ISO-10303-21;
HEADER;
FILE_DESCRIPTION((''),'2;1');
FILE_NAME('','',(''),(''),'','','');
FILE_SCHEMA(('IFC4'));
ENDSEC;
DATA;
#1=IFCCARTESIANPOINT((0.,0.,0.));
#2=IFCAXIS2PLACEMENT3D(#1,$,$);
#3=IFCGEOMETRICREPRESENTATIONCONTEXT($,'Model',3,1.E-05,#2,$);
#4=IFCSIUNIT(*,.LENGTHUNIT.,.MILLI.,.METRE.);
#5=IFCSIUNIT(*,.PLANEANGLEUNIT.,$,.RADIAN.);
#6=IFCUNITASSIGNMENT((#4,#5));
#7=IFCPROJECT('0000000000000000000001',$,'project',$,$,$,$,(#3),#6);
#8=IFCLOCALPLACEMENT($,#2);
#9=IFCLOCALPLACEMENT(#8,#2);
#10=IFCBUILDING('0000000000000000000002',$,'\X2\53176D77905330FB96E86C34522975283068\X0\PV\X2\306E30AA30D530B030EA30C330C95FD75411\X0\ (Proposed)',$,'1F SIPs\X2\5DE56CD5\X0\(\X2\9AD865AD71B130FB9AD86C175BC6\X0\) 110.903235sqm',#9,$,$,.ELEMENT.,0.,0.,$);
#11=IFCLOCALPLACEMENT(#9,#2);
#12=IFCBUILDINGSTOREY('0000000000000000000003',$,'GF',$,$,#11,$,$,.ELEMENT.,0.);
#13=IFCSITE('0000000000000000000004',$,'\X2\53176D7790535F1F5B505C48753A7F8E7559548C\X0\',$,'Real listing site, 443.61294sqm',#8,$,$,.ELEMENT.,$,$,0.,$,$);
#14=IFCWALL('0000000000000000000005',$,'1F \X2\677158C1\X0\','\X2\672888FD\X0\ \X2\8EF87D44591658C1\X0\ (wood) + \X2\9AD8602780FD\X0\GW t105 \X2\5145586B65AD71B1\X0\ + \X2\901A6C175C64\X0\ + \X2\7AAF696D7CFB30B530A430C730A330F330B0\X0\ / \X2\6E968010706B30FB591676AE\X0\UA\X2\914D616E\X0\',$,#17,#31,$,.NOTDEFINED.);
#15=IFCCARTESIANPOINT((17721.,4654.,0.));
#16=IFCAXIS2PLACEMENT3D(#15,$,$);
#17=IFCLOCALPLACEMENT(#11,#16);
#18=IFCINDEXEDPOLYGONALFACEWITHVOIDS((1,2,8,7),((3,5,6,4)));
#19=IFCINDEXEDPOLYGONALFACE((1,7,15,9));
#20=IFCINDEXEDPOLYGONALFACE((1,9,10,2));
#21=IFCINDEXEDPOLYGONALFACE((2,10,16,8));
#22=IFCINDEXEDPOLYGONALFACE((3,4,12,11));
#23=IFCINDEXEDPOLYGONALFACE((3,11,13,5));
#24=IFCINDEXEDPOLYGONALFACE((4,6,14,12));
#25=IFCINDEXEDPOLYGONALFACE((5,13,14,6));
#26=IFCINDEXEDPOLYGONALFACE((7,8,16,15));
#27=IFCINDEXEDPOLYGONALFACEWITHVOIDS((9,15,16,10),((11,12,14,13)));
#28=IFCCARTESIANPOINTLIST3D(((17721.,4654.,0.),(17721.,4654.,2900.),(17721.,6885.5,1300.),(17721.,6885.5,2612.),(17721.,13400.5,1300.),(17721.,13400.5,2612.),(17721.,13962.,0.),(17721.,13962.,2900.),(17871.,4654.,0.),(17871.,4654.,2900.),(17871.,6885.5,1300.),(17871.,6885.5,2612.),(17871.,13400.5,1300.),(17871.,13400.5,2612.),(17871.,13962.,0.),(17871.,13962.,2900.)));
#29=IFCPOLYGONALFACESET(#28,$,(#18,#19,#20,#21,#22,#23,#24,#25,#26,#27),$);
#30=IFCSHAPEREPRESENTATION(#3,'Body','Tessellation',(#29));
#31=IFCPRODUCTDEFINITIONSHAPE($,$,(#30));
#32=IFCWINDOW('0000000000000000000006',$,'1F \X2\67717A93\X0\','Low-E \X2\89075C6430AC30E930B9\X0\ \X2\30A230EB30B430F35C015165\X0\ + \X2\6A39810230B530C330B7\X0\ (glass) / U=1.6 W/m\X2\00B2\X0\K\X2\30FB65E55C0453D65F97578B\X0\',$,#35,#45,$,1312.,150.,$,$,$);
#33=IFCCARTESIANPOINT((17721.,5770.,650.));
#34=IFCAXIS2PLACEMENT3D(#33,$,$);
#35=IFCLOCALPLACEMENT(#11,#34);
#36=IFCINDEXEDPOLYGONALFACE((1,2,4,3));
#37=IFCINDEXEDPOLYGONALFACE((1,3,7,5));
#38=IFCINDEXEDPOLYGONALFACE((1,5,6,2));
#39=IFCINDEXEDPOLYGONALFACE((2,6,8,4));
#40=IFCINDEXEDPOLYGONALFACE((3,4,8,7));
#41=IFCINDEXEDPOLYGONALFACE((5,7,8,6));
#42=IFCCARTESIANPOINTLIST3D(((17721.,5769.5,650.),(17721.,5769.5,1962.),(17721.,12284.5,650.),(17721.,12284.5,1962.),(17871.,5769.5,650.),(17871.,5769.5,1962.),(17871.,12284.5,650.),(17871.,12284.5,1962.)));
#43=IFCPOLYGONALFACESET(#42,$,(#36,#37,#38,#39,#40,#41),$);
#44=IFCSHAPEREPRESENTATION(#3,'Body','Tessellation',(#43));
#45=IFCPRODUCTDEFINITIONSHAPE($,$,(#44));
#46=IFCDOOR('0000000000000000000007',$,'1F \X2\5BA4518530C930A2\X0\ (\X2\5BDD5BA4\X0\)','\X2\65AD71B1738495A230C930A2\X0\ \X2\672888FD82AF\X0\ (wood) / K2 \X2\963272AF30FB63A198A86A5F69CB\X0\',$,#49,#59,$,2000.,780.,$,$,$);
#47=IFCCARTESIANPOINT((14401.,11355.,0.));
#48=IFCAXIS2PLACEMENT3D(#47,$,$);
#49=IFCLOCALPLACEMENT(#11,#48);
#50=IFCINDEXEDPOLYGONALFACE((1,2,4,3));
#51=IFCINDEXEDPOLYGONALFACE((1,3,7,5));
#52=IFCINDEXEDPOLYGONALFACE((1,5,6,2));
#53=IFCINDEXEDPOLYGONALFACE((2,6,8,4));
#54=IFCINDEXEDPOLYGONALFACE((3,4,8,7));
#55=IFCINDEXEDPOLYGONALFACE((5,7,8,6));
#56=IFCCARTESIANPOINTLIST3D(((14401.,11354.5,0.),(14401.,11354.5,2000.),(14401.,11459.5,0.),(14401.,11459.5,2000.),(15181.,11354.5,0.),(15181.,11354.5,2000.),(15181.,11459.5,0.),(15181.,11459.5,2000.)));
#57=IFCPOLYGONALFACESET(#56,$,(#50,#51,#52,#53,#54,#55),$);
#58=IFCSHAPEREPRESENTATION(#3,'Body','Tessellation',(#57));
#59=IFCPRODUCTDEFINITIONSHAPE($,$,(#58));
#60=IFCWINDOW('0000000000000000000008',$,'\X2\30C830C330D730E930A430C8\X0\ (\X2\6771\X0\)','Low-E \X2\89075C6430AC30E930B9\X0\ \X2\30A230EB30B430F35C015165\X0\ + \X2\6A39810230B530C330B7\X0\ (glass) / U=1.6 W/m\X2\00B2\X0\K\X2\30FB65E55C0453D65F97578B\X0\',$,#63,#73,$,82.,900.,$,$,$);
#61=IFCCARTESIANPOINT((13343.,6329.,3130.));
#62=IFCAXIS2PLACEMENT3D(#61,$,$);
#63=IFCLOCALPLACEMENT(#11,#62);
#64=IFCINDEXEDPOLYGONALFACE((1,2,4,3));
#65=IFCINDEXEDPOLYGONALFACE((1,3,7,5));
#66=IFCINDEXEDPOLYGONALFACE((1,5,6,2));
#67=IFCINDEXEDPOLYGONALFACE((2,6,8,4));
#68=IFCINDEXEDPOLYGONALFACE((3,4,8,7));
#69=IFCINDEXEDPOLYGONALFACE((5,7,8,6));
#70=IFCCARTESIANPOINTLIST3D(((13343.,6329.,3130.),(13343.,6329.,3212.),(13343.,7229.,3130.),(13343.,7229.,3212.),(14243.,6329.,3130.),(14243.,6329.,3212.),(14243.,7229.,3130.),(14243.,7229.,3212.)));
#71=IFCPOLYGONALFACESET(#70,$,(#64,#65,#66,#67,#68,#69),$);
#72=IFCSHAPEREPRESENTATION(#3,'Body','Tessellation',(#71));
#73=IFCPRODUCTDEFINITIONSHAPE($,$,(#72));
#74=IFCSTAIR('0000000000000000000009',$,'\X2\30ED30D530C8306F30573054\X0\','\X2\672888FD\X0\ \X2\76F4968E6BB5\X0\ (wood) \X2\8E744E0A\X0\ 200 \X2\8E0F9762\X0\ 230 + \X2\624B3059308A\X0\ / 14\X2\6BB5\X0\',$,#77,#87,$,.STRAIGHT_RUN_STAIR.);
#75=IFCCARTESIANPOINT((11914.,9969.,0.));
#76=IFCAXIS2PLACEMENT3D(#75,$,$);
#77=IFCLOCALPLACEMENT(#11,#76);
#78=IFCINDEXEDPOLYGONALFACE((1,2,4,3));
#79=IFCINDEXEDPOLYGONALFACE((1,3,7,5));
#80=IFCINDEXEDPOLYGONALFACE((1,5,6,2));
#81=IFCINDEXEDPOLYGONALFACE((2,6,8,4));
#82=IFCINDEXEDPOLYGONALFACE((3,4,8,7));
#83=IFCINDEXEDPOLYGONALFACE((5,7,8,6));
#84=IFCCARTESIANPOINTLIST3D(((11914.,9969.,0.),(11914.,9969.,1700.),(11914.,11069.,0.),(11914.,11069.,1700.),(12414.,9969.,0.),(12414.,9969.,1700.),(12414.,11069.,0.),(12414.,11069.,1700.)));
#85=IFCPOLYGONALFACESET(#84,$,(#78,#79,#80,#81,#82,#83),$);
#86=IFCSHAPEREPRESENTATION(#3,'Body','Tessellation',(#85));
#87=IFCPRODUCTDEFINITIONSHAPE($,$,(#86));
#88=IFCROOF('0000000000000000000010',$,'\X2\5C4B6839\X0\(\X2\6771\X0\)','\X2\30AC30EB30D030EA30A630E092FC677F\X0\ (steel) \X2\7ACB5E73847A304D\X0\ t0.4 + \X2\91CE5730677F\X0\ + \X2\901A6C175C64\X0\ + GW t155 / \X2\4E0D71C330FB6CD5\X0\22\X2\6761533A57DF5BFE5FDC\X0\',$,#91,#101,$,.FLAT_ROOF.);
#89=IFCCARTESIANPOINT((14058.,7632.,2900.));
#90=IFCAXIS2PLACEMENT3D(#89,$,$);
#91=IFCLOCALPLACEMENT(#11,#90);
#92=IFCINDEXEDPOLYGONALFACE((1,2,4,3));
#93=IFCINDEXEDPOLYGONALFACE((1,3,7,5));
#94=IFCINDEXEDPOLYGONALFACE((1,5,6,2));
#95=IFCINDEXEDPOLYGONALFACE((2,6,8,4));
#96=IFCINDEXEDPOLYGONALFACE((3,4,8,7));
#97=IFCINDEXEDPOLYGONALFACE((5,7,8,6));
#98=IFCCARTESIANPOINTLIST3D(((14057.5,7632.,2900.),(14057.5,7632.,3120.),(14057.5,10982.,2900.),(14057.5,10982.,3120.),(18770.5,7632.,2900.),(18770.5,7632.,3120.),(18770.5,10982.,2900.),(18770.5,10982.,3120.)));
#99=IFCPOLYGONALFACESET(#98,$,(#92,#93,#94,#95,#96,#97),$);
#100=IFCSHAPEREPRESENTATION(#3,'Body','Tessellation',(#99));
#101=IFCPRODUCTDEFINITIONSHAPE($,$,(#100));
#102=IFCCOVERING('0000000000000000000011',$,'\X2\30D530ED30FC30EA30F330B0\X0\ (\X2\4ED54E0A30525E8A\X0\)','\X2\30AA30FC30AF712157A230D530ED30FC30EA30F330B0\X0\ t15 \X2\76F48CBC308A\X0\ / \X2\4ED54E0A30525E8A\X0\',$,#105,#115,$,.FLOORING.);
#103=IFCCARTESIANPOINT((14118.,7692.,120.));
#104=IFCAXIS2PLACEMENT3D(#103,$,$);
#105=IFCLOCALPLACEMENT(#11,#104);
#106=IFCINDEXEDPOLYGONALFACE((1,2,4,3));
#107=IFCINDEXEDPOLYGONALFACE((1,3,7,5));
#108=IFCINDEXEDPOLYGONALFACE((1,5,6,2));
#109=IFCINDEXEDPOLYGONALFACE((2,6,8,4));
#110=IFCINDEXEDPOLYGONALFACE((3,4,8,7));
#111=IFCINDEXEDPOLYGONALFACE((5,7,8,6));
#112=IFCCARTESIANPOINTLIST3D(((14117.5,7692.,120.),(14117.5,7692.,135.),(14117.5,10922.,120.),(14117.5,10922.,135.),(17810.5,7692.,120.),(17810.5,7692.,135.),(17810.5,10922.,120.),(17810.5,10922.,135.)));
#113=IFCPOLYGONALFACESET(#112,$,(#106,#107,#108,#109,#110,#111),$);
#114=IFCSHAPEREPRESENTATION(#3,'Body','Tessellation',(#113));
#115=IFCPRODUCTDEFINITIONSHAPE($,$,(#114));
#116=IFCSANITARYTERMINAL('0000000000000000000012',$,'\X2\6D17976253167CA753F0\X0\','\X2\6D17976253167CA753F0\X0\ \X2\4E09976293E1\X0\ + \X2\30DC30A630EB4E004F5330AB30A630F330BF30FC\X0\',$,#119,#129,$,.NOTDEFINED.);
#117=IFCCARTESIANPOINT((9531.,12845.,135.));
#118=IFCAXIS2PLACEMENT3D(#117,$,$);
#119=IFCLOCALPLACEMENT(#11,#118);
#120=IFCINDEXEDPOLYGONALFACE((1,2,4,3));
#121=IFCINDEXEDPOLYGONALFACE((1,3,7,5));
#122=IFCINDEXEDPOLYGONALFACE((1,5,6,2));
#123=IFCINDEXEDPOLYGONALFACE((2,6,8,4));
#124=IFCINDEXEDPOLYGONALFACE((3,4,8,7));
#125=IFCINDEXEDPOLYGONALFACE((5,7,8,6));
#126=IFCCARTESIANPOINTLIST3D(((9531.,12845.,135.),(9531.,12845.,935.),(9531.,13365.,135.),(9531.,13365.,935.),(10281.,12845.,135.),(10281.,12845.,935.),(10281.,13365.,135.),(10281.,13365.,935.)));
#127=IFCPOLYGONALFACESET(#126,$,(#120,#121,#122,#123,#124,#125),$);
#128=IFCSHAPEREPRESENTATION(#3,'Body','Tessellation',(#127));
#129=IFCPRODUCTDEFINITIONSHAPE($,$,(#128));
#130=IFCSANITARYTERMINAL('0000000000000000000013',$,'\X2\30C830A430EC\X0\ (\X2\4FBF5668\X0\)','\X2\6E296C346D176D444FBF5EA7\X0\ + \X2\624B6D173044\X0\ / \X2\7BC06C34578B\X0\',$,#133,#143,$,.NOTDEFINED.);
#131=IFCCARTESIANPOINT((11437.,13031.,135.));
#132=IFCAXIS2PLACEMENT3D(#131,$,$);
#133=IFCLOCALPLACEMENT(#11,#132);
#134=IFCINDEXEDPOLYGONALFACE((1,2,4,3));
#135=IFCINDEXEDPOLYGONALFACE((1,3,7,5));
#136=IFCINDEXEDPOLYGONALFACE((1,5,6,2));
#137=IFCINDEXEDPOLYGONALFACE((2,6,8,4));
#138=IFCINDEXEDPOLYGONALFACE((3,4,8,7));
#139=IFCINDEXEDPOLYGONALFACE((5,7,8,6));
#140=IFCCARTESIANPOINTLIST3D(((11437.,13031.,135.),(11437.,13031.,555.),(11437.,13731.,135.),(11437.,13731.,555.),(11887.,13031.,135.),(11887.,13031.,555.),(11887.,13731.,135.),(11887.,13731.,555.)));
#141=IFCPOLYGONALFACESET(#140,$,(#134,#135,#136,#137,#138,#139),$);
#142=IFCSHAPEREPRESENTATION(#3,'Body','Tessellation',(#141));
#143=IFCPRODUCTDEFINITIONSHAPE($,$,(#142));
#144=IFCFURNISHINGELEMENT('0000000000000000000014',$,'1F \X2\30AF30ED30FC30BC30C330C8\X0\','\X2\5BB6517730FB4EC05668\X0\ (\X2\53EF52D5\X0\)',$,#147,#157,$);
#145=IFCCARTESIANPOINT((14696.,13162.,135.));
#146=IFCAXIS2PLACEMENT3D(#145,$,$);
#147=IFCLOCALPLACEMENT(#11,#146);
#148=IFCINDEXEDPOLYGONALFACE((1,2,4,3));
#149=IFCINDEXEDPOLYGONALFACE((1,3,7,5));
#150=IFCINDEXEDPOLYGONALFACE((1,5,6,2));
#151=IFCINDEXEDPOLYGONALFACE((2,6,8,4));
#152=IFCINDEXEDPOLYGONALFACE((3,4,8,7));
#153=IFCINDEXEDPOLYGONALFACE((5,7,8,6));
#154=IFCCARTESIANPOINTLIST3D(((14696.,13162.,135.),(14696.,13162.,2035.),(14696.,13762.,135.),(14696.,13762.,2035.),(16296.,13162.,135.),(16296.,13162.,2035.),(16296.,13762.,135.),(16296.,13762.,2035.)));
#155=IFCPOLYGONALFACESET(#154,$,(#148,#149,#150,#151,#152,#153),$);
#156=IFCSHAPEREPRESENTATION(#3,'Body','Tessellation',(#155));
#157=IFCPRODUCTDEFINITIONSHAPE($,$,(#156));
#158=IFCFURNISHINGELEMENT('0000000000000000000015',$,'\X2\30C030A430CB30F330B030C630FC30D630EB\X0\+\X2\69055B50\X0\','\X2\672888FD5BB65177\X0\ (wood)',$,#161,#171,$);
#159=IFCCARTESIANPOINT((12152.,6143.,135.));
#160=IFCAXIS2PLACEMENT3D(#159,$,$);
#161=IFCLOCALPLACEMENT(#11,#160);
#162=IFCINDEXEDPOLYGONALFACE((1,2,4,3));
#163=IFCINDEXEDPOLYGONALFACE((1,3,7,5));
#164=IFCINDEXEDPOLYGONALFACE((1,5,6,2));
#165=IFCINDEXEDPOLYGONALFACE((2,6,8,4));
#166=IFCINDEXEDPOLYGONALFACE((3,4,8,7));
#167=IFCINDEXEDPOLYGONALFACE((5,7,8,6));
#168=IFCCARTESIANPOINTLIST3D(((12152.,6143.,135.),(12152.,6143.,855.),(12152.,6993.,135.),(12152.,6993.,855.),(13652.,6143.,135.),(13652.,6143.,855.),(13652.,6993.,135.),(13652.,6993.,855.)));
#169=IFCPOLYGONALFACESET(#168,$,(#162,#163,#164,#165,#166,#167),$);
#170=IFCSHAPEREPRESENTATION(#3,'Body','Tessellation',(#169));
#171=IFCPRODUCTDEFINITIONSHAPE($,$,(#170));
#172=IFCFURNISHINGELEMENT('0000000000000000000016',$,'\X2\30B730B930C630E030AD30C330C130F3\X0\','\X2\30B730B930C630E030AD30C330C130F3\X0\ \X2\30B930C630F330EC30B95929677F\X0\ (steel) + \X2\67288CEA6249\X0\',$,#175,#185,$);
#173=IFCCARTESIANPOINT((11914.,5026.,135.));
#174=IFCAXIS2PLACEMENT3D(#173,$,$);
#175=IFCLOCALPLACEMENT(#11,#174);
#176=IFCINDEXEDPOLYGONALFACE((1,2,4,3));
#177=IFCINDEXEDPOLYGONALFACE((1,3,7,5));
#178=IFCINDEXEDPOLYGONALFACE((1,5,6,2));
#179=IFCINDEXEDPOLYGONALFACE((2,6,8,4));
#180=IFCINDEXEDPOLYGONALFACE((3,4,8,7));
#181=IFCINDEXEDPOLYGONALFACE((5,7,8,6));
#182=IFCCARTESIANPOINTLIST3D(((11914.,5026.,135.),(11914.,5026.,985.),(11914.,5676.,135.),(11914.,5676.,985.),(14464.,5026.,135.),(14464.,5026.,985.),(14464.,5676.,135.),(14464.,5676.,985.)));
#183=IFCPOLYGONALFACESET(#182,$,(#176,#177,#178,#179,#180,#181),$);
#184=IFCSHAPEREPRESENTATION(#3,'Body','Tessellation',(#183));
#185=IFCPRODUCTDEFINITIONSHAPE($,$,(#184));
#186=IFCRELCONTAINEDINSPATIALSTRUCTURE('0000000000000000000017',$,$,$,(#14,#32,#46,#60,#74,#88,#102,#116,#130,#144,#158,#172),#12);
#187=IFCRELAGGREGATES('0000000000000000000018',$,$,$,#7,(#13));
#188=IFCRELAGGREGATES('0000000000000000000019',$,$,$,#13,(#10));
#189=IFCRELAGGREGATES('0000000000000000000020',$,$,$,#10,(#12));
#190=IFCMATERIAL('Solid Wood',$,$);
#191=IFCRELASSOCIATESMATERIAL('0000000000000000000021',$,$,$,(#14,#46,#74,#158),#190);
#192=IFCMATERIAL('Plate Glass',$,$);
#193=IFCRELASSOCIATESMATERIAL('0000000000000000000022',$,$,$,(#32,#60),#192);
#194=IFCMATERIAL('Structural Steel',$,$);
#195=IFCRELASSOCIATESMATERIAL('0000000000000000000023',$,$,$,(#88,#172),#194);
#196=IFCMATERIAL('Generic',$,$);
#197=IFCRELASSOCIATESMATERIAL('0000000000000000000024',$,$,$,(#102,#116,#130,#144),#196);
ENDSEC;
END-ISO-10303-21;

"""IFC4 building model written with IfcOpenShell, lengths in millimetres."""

from ifc_helpers import new_model, si_unit, frame, frame_2d, origin, place, context, project, spatial, rectangle, extrude, material, element, fill, save


model = new_model("IFC4")

# Units and contexts
model_context = context("Model", 3, precision=1e-05, world=origin())
ifc_project = project(units=[si_unit("LENGTHUNIT", "METRE", prefix="MILLI"), si_unit("PLANEANGLEUNIT", "RADIAN")], contexts=[model_context])

# Site, building, storey
site_placement = place(None, origin())
site = spatial("IfcSite", under=ifc_project, at=site_placement, Name="北海道弟子屈町美留和", ObjectType="Real listing site, 443.61294sqm", CompositionType="ELEMENT", RefElevation=0.0)
building_placement = place(site_placement, origin())
building = spatial("IfcBuilding", under=site, at=building_placement, Name="北海道・雨水利用とPVのオフグリッド志向 (Proposed)", ObjectType="1F SIPs工法(高断熱・高気密) 110.903235sqm", CompositionType="ELEMENT", ElevationOfRefHeight=0.0, ElevationOfTerrain=0.0)
storey_placement = place(building_placement, origin())
storey = spatial("IfcBuildingStorey", under=building, at=storey_placement, Name="GF", CompositionType="ELEMENT", Elevation=0.0)

# Shared definitions
ifc_material_1 = material(Name="Solid Wood")

# Wall, opening, window
wall_1_placement = place(storey_placement, frame((17721.0, 4654.0, 0.0)))
wall_1 = element("IfcWall", 1, at=wall_1_placement, inside=storey, material=ifc_material_1, Name="1F 東壁", Description="木製 軸組外壁 (wood) + 高性能GW t105 充填断熱 + 通気層 + 窯業系サイディング / 準耐火・外皮UA配慮", PredefinedType="NOTDEFINED", context=model_context, shape_type="SweptSolid", body=[
    extrude(rectangle(XDim=150.0, YDim=9308.0, at=frame_2d((75.0, 4654.0))), frame((17721.0, 4654.0, 0.0)), (0.0, 0.0, 1.0), 2900.0),
])
opening_1_placement = place(storey_placement, frame((17721.0, 5770.0, 650.0)))
opening_1 = element("IfcOpeningElement", 2, at=opening_1_placement, cuts=wall_1, PredefinedType="NOTDEFINED", context=model_context, shape_type="SweptSolid", body=[
    extrude(rectangle(XDim=150.0, YDim=6515.0, at=frame_2d((75.0, 3257.0))), frame((17721.0, 5770.0, 650.0)), (0.0, 0.0, 1.0), 1312.0),
])
ifc_material_2 = material(Name="Plate Glass")
window_1_placement = place(storey_placement, frame((17721.0, 5770.0, 650.0)))
window_1 = element("IfcWindow", 3, at=window_1_placement, inside=storey, material=ifc_material_2, Name="1F 東窓", Description="Low-E 複層ガラス アルゴン封入 + 樹脂サッシ (glass) / U=1.6 W/m²K・日射取得型", OverallHeight=1312.0, OverallWidth=150.0, context=model_context, shape_type="SweptSolid", body=[
    extrude(rectangle(XDim=150.0, YDim=6515.0, at=frame_2d((75.0, 3257.0))), frame((17721.0, 5770.0, 650.0)), (0.0, 0.0, 1.0), 1312.0),
])
fill(opening_1, window_1)

# Door
door_placement = place(storey_placement, frame((14401.0, 11355.0, 0.0)))
element("IfcDoor", 4, at=door_placement, inside=storey, material=ifc_material_1, Name="1F 室内ドア (寝室)", Description="断熱玄関ドア 木製芯 (wood) / K2 防犯・採風機構", OverallHeight=2000.0, OverallWidth=780.0, context=model_context, shape_type="SweptSolid", body=[
    extrude(rectangle(XDim=780.0, YDim=105.0, at=frame_2d((390.0, 52.0))), frame((14401.0, 11355.0, 0.0)), (0.0, 0.0, 1.0), 2000.0),
])

# Window
window_2_placement = place(storey_placement, frame((13343.0, 6329.0, 3130.0)))
element("IfcWindow", 5, at=window_2_placement, inside=storey, material=ifc_material_2, Name="トップライト (東)", Description="Low-E 複層ガラス アルゴン封入 + 樹脂サッシ (glass) / U=1.6 W/m²K・日射取得型", OverallHeight=82.0, OverallWidth=900.0, context=model_context, shape_type="SweptSolid", body=[
    extrude(rectangle(XDim=900.0, YDim=900.0, at=frame_2d((450.0, 450.0))), frame((13343.0, 6329.0, 3130.0)), (0.0, 0.0, 1.0), 82.0),
])

# Stair
stair_placement = place(storey_placement, frame((11914.0, 9969.0, 0.0)))
element("IfcStair", 6, at=stair_placement, inside=storey, material=ifc_material_1, Name="ロフトはしご", Description="木製 直階段 (wood) 蹴上 200 踏面 230 + 手すり / 14段", PredefinedType="STRAIGHT_RUN_STAIR", context=model_context, shape_type="SweptSolid", body=[
    extrude(rectangle(XDim=500.0, YDim=1100.0, at=frame_2d((250.0, 550.0))), frame((11914.0, 9969.0, 0.0)), (0.0, 0.0, 1.0), 1700.0),
])

# Roof
ifc_material_3 = material(Name="Structural Steel")
roof_placement = place(storey_placement, frame((14058.0, 7632.0, 2900.0)))
element("IfcRoof", 7, at=roof_placement, inside=storey, material=ifc_material_3, Name="屋根(東)", Description="ガルバリウム鋼板 (steel) 立平葺き t0.4 + 野地板 + 通気層 + GW t155 / 不燃・法22条区域対応", PredefinedType="FLAT_ROOF", context=model_context, shape_type="SweptSolid", body=[
    extrude(rectangle(XDim=4713.0, YDim=3350.0, at=frame_2d((2356.0, 1675.0))), frame((14058.0, 7632.0, 2900.0)), (0.0, 0.0, 1.0), 220.0),
])

# Covering
ifc_material_4 = material(Name="Generic")
covering_placement = place(storey_placement, frame((14118.0, 7692.0, 120.0)))
element("IfcCovering", 8, at=covering_placement, inside=storey, material=ifc_material_4, Name="フローリング (仕上げ床)", Description="オーク無垢フローリング t15 直貼り / 仕上げ床", PredefinedType="FLOORING", context=model_context, shape_type="SweptSolid", body=[
    extrude(rectangle(XDim=3693.0, YDim=3230.0, at=frame_2d((1846.0, 1615.0))), frame((14118.0, 7692.0, 120.0)), (0.0, 0.0, 1.0), 15.0),
])

# Sanitary terminals
sanitary_terminal_1_placement = place(storey_placement, frame((9531.0, 12845.0, 135.0)))
element("IfcSanitaryTerminal", 9, at=sanitary_terminal_1_placement, inside=storey, material=ifc_material_4, Name="洗面化粧台", Description="洗面化粧台 三面鏡 + ボウル一体カウンター", PredefinedType="NOTDEFINED", context=model_context, shape_type="SweptSolid", body=[
    extrude(rectangle(XDim=750.0, YDim=520.0, at=frame_2d((375.0, 260.0))), frame((9531.0, 12845.0, 135.0)), (0.0, 0.0, 1.0), 800.0),
])
sanitary_terminal_2_placement = place(storey_placement, frame((11437.0, 13031.0, 135.0)))
element("IfcSanitaryTerminal", 10, at=sanitary_terminal_2_placement, inside=storey, material=ifc_material_4, Name="トイレ (便器)", Description="温水洗浄便座 + 手洗い / 節水型", PredefinedType="NOTDEFINED", context=model_context, shape_type="SweptSolid", body=[
    extrude(rectangle(XDim=450.0, YDim=700.0, at=frame_2d((225.0, 350.0))), frame((11437.0, 13031.0, 135.0)), (0.0, 0.0, 1.0), 420.0),
])

# Furnishing elements
furnishing_1_placement = place(storey_placement, frame((14696.0, 13162.0, 135.0)))
element("IfcFurnishingElement", 11, at=furnishing_1_placement, inside=storey, material=ifc_material_4, Name="1F クローゼット", Description="家具・什器 (可動)", context=model_context, shape_type="SweptSolid", body=[
    extrude(rectangle(XDim=1600.0, YDim=600.0, at=frame_2d((800.0, 300.0))), frame((14696.0, 13162.0, 135.0)), (0.0, 0.0, 1.0), 1900.0),
])
furnishing_2_placement = place(storey_placement, frame((12152.0, 6143.0, 135.0)))
element("IfcFurnishingElement", 12, at=furnishing_2_placement, inside=storey, material=ifc_material_1, Name="ダイニングテーブル+椅子", Description="木製家具 (wood)", context=model_context, shape_type="SweptSolid", body=[
    extrude(rectangle(XDim=1500.0, YDim=850.0, at=frame_2d((750.0, 425.0))), frame((12152.0, 6143.0, 135.0)), (0.0, 0.0, 1.0), 720.0),
])
furnishing_3_placement = place(storey_placement, frame((11914.0, 5026.0, 135.0)))
element("IfcFurnishingElement", 13, at=furnishing_3_placement, inside=storey, material=ifc_material_3, Name="システムキッチン", Description="システムキッチン ステンレス天板 (steel) + 木質扉", context=model_context, shape_type="SweptSolid", body=[
    extrude(rectangle(XDim=2550.0, YDim=650.0, at=frame_2d((1275.0, 325.0))), frame((11914.0, 5026.0, 135.0)), (0.0, 0.0, 1.0), 850.0),
])

save(model, "model.ifc")
